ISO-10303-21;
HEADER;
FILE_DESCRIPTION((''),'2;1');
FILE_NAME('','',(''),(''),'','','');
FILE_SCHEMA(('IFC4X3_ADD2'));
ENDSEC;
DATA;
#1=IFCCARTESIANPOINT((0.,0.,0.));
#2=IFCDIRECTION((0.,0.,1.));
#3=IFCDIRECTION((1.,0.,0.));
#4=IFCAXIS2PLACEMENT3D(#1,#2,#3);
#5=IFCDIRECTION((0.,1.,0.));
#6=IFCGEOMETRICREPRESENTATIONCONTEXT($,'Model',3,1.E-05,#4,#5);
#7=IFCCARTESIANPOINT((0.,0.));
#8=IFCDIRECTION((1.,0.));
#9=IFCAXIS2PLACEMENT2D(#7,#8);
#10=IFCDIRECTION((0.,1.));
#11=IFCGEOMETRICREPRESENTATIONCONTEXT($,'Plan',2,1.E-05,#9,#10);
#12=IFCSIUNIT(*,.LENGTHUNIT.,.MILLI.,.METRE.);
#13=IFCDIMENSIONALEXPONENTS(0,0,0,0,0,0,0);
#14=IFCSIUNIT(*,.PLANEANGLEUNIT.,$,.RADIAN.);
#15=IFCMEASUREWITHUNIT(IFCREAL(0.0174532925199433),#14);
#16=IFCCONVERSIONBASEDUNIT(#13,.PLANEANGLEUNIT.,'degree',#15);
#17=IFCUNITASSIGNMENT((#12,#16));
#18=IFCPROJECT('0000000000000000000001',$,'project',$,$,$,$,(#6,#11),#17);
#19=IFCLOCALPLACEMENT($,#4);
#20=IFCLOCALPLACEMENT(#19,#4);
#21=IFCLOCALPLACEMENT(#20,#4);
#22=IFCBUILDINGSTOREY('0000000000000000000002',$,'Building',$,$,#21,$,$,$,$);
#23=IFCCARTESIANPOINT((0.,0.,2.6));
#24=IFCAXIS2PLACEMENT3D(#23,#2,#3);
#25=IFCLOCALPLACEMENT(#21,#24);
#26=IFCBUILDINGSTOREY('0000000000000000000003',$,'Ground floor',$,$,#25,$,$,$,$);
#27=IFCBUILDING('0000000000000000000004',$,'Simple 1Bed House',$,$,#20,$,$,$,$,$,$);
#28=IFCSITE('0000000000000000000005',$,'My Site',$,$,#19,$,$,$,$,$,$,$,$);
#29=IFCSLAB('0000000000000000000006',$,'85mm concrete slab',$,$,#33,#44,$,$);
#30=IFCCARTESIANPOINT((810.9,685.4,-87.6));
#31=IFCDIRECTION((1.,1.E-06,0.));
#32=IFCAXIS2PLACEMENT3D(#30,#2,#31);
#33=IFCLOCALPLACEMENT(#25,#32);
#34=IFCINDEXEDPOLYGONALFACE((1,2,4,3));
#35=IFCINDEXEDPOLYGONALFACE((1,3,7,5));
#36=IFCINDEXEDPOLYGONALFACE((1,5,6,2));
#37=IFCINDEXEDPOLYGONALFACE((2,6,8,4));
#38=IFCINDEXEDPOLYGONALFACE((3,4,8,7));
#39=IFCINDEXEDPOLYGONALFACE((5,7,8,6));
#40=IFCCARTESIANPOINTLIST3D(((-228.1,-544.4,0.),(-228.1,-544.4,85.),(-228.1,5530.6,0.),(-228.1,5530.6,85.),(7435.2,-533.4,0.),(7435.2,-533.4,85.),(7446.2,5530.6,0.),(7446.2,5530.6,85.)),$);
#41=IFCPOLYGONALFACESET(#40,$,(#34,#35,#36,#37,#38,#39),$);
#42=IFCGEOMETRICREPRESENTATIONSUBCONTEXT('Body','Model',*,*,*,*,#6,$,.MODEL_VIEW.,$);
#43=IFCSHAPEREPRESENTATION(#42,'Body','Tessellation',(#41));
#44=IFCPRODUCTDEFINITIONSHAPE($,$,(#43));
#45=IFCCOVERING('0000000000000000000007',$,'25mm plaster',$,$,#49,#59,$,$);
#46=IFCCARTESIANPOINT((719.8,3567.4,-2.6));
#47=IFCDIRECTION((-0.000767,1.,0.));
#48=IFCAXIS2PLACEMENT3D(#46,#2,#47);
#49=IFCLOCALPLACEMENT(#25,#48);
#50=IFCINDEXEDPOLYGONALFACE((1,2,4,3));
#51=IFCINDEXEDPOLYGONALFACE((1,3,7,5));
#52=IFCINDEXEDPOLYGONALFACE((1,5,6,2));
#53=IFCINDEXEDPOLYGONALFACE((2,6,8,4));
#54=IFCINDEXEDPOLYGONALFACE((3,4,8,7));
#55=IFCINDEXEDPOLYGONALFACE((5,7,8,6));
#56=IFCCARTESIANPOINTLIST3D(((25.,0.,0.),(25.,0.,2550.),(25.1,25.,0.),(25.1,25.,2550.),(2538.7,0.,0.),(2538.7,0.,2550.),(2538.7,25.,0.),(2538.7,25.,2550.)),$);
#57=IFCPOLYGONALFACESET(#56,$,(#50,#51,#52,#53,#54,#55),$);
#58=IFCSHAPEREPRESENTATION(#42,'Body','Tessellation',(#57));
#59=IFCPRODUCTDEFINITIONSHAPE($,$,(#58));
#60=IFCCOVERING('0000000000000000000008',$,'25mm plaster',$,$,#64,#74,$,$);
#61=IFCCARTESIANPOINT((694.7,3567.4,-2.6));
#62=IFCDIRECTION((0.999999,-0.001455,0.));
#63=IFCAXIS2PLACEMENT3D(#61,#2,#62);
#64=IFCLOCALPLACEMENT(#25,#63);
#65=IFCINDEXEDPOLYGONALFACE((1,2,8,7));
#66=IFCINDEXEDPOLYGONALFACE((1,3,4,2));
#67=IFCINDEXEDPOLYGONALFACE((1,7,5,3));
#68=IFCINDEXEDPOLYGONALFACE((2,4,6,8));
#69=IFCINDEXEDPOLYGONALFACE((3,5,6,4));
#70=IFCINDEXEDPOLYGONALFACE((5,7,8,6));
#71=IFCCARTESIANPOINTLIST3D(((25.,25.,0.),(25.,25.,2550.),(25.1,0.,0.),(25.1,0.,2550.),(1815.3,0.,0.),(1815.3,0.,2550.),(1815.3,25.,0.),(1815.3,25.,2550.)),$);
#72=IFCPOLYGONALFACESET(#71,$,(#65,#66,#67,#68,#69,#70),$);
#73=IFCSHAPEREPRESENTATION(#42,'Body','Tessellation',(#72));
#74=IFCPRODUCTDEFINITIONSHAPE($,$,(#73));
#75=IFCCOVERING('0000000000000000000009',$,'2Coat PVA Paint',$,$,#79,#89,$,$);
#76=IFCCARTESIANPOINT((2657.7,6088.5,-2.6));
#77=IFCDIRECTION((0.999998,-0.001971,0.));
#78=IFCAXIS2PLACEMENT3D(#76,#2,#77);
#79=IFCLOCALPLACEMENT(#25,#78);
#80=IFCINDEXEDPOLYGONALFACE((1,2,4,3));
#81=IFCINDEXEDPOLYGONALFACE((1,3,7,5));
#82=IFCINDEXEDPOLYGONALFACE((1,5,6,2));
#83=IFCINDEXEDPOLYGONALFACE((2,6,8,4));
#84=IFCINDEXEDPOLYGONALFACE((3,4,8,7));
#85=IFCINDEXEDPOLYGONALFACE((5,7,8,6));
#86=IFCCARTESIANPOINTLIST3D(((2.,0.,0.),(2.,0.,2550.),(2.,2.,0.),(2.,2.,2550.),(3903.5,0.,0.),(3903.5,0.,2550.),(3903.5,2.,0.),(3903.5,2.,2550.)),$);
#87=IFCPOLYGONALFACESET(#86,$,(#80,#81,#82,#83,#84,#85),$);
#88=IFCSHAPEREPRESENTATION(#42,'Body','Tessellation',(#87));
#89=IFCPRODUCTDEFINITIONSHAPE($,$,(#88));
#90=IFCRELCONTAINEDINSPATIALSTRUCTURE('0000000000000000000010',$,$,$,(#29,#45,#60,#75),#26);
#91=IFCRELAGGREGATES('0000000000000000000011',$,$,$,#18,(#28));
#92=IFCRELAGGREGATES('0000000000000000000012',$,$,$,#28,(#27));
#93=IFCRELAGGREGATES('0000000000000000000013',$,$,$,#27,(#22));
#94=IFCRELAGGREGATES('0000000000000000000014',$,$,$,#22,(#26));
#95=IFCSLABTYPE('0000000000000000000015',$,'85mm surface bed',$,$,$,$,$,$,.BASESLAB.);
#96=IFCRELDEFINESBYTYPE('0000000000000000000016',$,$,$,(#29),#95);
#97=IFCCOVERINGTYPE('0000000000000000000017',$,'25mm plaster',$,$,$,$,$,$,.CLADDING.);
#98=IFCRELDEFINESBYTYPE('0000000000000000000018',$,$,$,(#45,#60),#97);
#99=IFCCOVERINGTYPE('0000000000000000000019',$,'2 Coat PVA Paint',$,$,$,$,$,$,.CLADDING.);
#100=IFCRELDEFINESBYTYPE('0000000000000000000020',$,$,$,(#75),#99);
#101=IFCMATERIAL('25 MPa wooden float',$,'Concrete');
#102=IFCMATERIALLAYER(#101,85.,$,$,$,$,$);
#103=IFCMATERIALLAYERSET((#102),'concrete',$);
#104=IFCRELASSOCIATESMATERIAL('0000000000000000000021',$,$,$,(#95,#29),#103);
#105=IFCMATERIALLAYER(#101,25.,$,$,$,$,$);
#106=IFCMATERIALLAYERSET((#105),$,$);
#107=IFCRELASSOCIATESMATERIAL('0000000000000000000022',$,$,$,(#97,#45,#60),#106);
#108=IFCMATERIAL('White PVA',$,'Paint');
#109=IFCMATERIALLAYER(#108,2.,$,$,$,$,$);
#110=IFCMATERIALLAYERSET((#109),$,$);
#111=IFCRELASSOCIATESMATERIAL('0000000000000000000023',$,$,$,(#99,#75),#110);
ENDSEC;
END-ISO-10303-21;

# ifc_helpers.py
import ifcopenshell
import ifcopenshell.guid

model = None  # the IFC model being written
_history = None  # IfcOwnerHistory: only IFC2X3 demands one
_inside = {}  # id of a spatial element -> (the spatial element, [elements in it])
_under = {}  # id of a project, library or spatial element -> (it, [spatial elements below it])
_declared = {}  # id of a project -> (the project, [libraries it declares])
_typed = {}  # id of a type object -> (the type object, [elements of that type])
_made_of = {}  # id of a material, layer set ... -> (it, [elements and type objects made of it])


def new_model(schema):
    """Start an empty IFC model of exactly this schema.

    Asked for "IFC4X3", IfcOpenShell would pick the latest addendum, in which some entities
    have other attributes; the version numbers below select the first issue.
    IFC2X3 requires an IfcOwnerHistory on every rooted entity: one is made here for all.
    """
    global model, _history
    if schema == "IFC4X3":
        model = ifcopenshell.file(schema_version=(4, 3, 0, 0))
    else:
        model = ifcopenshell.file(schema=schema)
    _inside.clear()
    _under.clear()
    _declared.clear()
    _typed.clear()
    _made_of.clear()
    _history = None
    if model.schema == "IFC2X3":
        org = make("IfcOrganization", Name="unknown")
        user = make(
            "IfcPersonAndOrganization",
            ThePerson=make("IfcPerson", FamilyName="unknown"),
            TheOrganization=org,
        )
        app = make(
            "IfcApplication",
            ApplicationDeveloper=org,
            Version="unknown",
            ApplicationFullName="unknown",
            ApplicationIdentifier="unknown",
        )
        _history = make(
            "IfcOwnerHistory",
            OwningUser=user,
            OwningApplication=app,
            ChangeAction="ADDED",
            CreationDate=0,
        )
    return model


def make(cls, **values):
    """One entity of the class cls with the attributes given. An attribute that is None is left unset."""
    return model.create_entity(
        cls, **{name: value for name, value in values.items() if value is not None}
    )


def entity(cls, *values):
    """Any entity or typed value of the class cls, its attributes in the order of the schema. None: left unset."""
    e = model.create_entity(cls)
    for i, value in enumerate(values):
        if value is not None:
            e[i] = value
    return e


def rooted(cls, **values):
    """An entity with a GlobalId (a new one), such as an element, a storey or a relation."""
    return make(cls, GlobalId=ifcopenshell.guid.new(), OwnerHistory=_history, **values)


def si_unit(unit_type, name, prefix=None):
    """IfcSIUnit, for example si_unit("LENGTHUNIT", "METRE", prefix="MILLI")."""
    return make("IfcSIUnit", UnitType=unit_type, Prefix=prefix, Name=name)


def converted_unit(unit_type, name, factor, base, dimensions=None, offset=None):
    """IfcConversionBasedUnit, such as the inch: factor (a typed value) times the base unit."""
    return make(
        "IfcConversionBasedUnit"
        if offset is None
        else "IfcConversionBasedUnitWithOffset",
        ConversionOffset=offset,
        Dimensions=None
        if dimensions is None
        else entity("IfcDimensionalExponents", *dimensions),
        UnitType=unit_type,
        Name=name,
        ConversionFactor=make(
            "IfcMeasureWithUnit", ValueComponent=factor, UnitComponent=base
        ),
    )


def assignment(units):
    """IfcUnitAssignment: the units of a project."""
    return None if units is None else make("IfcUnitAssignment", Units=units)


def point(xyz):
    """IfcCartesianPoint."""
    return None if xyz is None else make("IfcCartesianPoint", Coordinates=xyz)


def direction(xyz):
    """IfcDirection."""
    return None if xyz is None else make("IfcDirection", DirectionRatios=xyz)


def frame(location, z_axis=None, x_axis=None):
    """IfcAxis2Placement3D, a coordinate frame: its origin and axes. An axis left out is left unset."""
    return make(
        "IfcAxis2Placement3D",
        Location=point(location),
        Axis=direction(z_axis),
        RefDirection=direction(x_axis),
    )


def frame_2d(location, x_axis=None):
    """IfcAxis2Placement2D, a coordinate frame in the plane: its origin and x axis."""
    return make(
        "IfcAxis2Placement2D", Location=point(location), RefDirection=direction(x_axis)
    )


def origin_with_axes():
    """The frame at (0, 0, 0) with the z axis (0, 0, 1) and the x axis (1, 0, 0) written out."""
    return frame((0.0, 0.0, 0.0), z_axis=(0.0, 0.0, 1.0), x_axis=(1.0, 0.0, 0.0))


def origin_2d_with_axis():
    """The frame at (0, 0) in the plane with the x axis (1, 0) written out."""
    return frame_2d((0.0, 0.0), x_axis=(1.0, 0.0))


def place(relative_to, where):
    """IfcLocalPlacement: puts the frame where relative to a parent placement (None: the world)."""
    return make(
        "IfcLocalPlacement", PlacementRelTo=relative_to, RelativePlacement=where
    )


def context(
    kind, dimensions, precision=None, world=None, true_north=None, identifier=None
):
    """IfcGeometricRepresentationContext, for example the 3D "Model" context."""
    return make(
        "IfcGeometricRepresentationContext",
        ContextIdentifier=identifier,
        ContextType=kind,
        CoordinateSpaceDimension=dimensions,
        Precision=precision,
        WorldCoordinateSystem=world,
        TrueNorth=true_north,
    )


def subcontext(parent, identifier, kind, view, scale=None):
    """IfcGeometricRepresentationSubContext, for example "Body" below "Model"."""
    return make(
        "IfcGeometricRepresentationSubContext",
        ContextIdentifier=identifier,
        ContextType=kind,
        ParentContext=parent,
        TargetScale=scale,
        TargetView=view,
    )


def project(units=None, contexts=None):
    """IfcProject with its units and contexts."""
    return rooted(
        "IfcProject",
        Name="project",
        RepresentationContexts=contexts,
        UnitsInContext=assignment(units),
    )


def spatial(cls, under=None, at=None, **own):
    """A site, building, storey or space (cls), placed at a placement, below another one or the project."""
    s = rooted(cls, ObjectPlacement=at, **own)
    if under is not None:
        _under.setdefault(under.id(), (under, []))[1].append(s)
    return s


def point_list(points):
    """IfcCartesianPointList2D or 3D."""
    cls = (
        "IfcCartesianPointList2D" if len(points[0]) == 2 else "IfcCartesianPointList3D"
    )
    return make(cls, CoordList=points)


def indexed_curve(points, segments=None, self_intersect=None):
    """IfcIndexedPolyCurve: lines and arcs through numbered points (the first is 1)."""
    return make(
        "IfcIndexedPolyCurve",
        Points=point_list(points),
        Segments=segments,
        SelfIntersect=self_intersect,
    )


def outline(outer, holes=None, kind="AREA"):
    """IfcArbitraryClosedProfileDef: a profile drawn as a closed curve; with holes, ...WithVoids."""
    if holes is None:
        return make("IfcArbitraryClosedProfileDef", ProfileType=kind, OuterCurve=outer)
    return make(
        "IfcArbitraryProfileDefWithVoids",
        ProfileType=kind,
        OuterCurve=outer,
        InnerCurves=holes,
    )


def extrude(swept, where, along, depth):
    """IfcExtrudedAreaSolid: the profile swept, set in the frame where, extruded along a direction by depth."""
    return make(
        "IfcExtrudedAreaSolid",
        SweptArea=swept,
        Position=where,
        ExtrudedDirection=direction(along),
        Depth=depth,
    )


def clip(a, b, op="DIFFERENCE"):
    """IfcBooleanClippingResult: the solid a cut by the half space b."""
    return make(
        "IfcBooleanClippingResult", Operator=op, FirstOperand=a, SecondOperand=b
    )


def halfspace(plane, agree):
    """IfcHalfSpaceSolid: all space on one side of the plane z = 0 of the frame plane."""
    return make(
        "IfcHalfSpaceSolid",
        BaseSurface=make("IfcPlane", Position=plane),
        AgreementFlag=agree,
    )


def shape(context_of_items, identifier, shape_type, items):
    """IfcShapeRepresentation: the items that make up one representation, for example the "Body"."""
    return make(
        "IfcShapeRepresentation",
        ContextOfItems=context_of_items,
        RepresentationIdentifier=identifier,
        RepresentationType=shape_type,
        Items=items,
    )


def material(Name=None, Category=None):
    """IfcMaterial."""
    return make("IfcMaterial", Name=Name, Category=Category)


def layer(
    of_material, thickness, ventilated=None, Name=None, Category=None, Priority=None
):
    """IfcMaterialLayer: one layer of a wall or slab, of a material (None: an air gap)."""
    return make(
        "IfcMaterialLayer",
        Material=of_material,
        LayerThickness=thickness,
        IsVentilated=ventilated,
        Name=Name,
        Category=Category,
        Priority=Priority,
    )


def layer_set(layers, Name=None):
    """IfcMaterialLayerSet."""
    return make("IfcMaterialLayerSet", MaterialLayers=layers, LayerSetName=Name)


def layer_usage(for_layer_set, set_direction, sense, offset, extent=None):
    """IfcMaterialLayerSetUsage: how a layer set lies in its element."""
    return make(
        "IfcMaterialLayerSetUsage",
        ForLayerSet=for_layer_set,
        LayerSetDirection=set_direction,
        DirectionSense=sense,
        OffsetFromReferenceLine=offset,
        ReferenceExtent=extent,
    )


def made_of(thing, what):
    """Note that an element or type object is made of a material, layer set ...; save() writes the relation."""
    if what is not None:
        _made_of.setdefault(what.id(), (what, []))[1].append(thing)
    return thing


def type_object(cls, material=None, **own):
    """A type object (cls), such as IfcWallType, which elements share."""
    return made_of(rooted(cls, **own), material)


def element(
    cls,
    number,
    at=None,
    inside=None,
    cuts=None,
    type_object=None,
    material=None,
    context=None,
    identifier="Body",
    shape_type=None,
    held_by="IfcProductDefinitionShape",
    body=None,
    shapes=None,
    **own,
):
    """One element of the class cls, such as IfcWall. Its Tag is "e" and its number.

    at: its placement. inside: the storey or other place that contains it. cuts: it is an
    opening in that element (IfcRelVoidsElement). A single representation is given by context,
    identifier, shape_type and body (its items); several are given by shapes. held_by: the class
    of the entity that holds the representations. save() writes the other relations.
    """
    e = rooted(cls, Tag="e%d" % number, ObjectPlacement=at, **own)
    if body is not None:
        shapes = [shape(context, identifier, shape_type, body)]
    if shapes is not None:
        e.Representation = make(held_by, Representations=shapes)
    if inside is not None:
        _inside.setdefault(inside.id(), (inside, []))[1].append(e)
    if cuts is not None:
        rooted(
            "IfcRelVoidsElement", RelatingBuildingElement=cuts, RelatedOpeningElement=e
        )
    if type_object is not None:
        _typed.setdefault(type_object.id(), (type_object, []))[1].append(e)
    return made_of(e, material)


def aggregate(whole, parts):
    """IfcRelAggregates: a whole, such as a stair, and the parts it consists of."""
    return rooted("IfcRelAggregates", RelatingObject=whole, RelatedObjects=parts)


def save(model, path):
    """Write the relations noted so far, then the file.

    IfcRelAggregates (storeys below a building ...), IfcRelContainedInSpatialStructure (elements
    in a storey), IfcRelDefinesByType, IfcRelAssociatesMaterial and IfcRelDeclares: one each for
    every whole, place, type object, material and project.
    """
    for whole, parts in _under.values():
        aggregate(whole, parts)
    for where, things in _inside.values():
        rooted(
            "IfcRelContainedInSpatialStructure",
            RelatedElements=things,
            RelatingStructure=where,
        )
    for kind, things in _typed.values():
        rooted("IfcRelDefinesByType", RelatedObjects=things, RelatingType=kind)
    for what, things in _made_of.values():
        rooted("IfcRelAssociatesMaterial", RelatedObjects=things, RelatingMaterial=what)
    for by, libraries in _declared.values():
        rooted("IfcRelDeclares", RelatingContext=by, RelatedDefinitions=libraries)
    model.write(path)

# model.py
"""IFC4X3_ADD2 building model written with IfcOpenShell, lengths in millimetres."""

from ifc_helpers import new_model, entity, si_unit, converted_unit, direction, frame, origin_with_axes, origin_2d_with_axis, place, context, subcontext, project, spatial, indexed_curve, outline, extrude, clip, halfspace, material, layer, layer_set, layer_usage, type_object, element, save


model = new_model("IFC4X3_ADD2")

# Units and contexts
model_context = context("Model", 3, precision=1e-05, world=origin_with_axes(), true_north=direction((0.0, 1.0, 0.0)))
plan_context = context("Plan", 2, precision=1e-05, world=origin_2d_with_axis(), true_north=direction((0.0, 1.0)))
body_context_1 = subcontext(model_context, "Body", "Model", "MODEL_VIEW")
ifc_project = project(units=[si_unit("LENGTHUNIT", "METRE", prefix="MILLI"), converted_unit("PLANEANGLEUNIT", "degree", entity("IfcReal", 0.0174532925199433), si_unit("PLANEANGLEUNIT", "RADIAN"), dimensions=[0, 0, 0, 0, 0, 0, 0])], contexts=[model_context, plan_context])

# Site, building, storeys
site_placement = place(None, origin_with_axes())
site = spatial("IfcSite", under=ifc_project, at=site_placement, Name="My Site")
building_placement = place(site_placement, origin_with_axes())
building = spatial("IfcBuilding", under=site, at=building_placement, Name="Simple 1Bed House")
storey_1_placement = place(building_placement, origin_with_axes())
storey_1 = spatial("IfcBuildingStorey", under=building, at=storey_1_placement, Name="Building")
storey_2_placement = place(storey_1_placement, frame((0.0, 0.0, 2.6), z_axis=(0.0, 0.0, 1.0), x_axis=(1.0, 0.0, 0.0)))
storey_2 = spatial("IfcBuildingStorey", under=storey_1, at=storey_2_placement, Name="Ground floor")

# Slab
ifc_material_1 = material(Name="25 MPa wooden float", Category="Concrete")
ifc_layer_1 = layer(ifc_material_1, 85.0)
ifc_layer_set_1 = layer_set([ifc_layer_1], Name="concrete")
ifc_layer_usage_1 = layer_usage(ifc_layer_set_1, "AXIS3", "POSITIVE", 0.0)
slab_type = type_object("IfcSlabType", Name="85mm surface bed", PredefinedType="BASESLAB", material=ifc_layer_set_1)
slab_placement = place(storey_2_placement, frame((810.9, 685.4, -87.6), z_axis=(0.0, 0.0, 1.0), x_axis=(1.0, 0.000001, 0.0)))
element("IfcSlab", 1, at=slab_placement, inside=storey_2, type_object=slab_type, material=ifc_layer_usage_1, Name="85mm concrete slab", context=body_context_1, shape_type="SolidModel", body=[
    extrude(outline(indexed_curve([(-228.1, -544.4), (-228.1, 5530.6), (7446.2, 5530.6), (7435.2, -533.4), (-228.1, -544.4)])), None, (0.0, 0.0, 1.0), 85.0),
])

# Coverings
ifc_layer_2 = layer(ifc_material_1, 25.0)
ifc_layer_set_2 = layer_set([ifc_layer_2])
ifc_layer_usage_2 = layer_usage(ifc_layer_set_2, "AXIS2", "POSITIVE", 0.0)
covering_type_1 = type_object("IfcCoveringType", Name="25mm plaster", PredefinedType="CLADDING", material=ifc_layer_set_2)
covering_1_placement = place(storey_2_placement, frame((719.8, 3567.4, -2.6), z_axis=(0.0, 0.0, 1.0), x_axis=(-0.000767, 1.0, 0.0)))
element("IfcCovering", 2, at=covering_1_placement, inside=storey_2, type_object=covering_type_1, material=ifc_layer_usage_2, Name="25mm plaster", context=body_context_1, shape_type="Clipping", body=[
    clip(clip(extrude(outline(indexed_curve([(0.0, 0.0), (0.0, 25.0), (2538.7, 25.0), (2538.7, 0.0), (0.0, 0.0)], self_intersect=False)), origin_with_axes(), (0.0, 0.0, 1.0), 2550.0), halfspace(frame((25.0, 0.0, 0.0), z_axis=(-0.06375, 0.000142, 0.0), x_axis=(0.002226, 0.999998, 0.0)), False)), halfspace(frame((2538.6, 0.0, 0.0), z_axis=(0.06375, -0.000141, 0.0), x_axis=(-0.002216, -0.999998, 0.0)), False)),
])
ifc_layer_usage_3 = layer_usage(ifc_layer_set_2, "AXIS2", "POSITIVE", 0.0)
covering_2_placement = place(storey_2_placement, frame((694.7, 3567.4, -2.6), z_axis=(0.0, 0.0, 1.0), x_axis=(0.999999, -0.001455, 0.0)))
element("IfcCovering", 3, at=covering_2_placement, inside=storey_2, type_object=covering_type_1, material=ifc_layer_usage_3, Name="25mm plaster", context=body_context_1, shape_type="Clipping", body=[
    clip(extrude(outline(indexed_curve([(0.0, 0.0), (0.0, 25.0), (1815.3, 25.0), (1815.3, 0.0), (0.0, 0.0)], self_intersect=False)), origin_with_axes(), (0.0, 0.0, 1.0), 2550.0), halfspace(frame((25.1, 0.0, 0.0), z_axis=(-0.06375, -0.000142, 0.0), x_axis=(-0.00222, 0.999998, 0.0)), False)),
])
ifc_material_2 = material(Name="White PVA", Category="Paint")
ifc_layer_3 = layer(ifc_material_2, 2.0)
ifc_layer_set_3 = layer_set([ifc_layer_3])
ifc_layer_usage_4 = layer_usage(ifc_layer_set_3, "AXIS2", "POSITIVE", 0.0)
covering_type_2 = type_object("IfcCoveringType", Name="2 Coat PVA Paint", PredefinedType="CLADDING", material=ifc_layer_set_3)
covering_3_placement = place(storey_2_placement, frame((2657.7, 6088.5, -2.6), z_axis=(0.0, 0.0, 1.0), x_axis=(0.999998, -0.001971, 0.0)))
element("IfcCovering", 4, at=covering_3_placement, inside=storey_2, type_object=covering_type_2, material=ifc_layer_usage_4, Name="2Coat PVA Paint", context=body_context_1, shape_type="Clipping", body=[
    clip(clip(extrude(outline(indexed_curve([(0.0, 0.0), (0.0, 2.0), (3903.5, 2.0), (3903.5, 0.0), (0.0, 0.0)], self_intersect=False)), origin_with_axes(), (0.0, 0.0, 1.0), 2550.0), halfspace(frame((2.0, 0.0, 0.0), z_axis=(-0.999998, -0.001971, 0.0), x_axis=(-0.001971, 0.999998, 0.0)), False)), halfspace(frame((3904.3, -407.5, 2050.0), z_axis=(0.999998, 0.001971, 0.0), x_axis=(0.001971, -0.999998, 0.0)), False)),
])

save(model, "model.ifc")
